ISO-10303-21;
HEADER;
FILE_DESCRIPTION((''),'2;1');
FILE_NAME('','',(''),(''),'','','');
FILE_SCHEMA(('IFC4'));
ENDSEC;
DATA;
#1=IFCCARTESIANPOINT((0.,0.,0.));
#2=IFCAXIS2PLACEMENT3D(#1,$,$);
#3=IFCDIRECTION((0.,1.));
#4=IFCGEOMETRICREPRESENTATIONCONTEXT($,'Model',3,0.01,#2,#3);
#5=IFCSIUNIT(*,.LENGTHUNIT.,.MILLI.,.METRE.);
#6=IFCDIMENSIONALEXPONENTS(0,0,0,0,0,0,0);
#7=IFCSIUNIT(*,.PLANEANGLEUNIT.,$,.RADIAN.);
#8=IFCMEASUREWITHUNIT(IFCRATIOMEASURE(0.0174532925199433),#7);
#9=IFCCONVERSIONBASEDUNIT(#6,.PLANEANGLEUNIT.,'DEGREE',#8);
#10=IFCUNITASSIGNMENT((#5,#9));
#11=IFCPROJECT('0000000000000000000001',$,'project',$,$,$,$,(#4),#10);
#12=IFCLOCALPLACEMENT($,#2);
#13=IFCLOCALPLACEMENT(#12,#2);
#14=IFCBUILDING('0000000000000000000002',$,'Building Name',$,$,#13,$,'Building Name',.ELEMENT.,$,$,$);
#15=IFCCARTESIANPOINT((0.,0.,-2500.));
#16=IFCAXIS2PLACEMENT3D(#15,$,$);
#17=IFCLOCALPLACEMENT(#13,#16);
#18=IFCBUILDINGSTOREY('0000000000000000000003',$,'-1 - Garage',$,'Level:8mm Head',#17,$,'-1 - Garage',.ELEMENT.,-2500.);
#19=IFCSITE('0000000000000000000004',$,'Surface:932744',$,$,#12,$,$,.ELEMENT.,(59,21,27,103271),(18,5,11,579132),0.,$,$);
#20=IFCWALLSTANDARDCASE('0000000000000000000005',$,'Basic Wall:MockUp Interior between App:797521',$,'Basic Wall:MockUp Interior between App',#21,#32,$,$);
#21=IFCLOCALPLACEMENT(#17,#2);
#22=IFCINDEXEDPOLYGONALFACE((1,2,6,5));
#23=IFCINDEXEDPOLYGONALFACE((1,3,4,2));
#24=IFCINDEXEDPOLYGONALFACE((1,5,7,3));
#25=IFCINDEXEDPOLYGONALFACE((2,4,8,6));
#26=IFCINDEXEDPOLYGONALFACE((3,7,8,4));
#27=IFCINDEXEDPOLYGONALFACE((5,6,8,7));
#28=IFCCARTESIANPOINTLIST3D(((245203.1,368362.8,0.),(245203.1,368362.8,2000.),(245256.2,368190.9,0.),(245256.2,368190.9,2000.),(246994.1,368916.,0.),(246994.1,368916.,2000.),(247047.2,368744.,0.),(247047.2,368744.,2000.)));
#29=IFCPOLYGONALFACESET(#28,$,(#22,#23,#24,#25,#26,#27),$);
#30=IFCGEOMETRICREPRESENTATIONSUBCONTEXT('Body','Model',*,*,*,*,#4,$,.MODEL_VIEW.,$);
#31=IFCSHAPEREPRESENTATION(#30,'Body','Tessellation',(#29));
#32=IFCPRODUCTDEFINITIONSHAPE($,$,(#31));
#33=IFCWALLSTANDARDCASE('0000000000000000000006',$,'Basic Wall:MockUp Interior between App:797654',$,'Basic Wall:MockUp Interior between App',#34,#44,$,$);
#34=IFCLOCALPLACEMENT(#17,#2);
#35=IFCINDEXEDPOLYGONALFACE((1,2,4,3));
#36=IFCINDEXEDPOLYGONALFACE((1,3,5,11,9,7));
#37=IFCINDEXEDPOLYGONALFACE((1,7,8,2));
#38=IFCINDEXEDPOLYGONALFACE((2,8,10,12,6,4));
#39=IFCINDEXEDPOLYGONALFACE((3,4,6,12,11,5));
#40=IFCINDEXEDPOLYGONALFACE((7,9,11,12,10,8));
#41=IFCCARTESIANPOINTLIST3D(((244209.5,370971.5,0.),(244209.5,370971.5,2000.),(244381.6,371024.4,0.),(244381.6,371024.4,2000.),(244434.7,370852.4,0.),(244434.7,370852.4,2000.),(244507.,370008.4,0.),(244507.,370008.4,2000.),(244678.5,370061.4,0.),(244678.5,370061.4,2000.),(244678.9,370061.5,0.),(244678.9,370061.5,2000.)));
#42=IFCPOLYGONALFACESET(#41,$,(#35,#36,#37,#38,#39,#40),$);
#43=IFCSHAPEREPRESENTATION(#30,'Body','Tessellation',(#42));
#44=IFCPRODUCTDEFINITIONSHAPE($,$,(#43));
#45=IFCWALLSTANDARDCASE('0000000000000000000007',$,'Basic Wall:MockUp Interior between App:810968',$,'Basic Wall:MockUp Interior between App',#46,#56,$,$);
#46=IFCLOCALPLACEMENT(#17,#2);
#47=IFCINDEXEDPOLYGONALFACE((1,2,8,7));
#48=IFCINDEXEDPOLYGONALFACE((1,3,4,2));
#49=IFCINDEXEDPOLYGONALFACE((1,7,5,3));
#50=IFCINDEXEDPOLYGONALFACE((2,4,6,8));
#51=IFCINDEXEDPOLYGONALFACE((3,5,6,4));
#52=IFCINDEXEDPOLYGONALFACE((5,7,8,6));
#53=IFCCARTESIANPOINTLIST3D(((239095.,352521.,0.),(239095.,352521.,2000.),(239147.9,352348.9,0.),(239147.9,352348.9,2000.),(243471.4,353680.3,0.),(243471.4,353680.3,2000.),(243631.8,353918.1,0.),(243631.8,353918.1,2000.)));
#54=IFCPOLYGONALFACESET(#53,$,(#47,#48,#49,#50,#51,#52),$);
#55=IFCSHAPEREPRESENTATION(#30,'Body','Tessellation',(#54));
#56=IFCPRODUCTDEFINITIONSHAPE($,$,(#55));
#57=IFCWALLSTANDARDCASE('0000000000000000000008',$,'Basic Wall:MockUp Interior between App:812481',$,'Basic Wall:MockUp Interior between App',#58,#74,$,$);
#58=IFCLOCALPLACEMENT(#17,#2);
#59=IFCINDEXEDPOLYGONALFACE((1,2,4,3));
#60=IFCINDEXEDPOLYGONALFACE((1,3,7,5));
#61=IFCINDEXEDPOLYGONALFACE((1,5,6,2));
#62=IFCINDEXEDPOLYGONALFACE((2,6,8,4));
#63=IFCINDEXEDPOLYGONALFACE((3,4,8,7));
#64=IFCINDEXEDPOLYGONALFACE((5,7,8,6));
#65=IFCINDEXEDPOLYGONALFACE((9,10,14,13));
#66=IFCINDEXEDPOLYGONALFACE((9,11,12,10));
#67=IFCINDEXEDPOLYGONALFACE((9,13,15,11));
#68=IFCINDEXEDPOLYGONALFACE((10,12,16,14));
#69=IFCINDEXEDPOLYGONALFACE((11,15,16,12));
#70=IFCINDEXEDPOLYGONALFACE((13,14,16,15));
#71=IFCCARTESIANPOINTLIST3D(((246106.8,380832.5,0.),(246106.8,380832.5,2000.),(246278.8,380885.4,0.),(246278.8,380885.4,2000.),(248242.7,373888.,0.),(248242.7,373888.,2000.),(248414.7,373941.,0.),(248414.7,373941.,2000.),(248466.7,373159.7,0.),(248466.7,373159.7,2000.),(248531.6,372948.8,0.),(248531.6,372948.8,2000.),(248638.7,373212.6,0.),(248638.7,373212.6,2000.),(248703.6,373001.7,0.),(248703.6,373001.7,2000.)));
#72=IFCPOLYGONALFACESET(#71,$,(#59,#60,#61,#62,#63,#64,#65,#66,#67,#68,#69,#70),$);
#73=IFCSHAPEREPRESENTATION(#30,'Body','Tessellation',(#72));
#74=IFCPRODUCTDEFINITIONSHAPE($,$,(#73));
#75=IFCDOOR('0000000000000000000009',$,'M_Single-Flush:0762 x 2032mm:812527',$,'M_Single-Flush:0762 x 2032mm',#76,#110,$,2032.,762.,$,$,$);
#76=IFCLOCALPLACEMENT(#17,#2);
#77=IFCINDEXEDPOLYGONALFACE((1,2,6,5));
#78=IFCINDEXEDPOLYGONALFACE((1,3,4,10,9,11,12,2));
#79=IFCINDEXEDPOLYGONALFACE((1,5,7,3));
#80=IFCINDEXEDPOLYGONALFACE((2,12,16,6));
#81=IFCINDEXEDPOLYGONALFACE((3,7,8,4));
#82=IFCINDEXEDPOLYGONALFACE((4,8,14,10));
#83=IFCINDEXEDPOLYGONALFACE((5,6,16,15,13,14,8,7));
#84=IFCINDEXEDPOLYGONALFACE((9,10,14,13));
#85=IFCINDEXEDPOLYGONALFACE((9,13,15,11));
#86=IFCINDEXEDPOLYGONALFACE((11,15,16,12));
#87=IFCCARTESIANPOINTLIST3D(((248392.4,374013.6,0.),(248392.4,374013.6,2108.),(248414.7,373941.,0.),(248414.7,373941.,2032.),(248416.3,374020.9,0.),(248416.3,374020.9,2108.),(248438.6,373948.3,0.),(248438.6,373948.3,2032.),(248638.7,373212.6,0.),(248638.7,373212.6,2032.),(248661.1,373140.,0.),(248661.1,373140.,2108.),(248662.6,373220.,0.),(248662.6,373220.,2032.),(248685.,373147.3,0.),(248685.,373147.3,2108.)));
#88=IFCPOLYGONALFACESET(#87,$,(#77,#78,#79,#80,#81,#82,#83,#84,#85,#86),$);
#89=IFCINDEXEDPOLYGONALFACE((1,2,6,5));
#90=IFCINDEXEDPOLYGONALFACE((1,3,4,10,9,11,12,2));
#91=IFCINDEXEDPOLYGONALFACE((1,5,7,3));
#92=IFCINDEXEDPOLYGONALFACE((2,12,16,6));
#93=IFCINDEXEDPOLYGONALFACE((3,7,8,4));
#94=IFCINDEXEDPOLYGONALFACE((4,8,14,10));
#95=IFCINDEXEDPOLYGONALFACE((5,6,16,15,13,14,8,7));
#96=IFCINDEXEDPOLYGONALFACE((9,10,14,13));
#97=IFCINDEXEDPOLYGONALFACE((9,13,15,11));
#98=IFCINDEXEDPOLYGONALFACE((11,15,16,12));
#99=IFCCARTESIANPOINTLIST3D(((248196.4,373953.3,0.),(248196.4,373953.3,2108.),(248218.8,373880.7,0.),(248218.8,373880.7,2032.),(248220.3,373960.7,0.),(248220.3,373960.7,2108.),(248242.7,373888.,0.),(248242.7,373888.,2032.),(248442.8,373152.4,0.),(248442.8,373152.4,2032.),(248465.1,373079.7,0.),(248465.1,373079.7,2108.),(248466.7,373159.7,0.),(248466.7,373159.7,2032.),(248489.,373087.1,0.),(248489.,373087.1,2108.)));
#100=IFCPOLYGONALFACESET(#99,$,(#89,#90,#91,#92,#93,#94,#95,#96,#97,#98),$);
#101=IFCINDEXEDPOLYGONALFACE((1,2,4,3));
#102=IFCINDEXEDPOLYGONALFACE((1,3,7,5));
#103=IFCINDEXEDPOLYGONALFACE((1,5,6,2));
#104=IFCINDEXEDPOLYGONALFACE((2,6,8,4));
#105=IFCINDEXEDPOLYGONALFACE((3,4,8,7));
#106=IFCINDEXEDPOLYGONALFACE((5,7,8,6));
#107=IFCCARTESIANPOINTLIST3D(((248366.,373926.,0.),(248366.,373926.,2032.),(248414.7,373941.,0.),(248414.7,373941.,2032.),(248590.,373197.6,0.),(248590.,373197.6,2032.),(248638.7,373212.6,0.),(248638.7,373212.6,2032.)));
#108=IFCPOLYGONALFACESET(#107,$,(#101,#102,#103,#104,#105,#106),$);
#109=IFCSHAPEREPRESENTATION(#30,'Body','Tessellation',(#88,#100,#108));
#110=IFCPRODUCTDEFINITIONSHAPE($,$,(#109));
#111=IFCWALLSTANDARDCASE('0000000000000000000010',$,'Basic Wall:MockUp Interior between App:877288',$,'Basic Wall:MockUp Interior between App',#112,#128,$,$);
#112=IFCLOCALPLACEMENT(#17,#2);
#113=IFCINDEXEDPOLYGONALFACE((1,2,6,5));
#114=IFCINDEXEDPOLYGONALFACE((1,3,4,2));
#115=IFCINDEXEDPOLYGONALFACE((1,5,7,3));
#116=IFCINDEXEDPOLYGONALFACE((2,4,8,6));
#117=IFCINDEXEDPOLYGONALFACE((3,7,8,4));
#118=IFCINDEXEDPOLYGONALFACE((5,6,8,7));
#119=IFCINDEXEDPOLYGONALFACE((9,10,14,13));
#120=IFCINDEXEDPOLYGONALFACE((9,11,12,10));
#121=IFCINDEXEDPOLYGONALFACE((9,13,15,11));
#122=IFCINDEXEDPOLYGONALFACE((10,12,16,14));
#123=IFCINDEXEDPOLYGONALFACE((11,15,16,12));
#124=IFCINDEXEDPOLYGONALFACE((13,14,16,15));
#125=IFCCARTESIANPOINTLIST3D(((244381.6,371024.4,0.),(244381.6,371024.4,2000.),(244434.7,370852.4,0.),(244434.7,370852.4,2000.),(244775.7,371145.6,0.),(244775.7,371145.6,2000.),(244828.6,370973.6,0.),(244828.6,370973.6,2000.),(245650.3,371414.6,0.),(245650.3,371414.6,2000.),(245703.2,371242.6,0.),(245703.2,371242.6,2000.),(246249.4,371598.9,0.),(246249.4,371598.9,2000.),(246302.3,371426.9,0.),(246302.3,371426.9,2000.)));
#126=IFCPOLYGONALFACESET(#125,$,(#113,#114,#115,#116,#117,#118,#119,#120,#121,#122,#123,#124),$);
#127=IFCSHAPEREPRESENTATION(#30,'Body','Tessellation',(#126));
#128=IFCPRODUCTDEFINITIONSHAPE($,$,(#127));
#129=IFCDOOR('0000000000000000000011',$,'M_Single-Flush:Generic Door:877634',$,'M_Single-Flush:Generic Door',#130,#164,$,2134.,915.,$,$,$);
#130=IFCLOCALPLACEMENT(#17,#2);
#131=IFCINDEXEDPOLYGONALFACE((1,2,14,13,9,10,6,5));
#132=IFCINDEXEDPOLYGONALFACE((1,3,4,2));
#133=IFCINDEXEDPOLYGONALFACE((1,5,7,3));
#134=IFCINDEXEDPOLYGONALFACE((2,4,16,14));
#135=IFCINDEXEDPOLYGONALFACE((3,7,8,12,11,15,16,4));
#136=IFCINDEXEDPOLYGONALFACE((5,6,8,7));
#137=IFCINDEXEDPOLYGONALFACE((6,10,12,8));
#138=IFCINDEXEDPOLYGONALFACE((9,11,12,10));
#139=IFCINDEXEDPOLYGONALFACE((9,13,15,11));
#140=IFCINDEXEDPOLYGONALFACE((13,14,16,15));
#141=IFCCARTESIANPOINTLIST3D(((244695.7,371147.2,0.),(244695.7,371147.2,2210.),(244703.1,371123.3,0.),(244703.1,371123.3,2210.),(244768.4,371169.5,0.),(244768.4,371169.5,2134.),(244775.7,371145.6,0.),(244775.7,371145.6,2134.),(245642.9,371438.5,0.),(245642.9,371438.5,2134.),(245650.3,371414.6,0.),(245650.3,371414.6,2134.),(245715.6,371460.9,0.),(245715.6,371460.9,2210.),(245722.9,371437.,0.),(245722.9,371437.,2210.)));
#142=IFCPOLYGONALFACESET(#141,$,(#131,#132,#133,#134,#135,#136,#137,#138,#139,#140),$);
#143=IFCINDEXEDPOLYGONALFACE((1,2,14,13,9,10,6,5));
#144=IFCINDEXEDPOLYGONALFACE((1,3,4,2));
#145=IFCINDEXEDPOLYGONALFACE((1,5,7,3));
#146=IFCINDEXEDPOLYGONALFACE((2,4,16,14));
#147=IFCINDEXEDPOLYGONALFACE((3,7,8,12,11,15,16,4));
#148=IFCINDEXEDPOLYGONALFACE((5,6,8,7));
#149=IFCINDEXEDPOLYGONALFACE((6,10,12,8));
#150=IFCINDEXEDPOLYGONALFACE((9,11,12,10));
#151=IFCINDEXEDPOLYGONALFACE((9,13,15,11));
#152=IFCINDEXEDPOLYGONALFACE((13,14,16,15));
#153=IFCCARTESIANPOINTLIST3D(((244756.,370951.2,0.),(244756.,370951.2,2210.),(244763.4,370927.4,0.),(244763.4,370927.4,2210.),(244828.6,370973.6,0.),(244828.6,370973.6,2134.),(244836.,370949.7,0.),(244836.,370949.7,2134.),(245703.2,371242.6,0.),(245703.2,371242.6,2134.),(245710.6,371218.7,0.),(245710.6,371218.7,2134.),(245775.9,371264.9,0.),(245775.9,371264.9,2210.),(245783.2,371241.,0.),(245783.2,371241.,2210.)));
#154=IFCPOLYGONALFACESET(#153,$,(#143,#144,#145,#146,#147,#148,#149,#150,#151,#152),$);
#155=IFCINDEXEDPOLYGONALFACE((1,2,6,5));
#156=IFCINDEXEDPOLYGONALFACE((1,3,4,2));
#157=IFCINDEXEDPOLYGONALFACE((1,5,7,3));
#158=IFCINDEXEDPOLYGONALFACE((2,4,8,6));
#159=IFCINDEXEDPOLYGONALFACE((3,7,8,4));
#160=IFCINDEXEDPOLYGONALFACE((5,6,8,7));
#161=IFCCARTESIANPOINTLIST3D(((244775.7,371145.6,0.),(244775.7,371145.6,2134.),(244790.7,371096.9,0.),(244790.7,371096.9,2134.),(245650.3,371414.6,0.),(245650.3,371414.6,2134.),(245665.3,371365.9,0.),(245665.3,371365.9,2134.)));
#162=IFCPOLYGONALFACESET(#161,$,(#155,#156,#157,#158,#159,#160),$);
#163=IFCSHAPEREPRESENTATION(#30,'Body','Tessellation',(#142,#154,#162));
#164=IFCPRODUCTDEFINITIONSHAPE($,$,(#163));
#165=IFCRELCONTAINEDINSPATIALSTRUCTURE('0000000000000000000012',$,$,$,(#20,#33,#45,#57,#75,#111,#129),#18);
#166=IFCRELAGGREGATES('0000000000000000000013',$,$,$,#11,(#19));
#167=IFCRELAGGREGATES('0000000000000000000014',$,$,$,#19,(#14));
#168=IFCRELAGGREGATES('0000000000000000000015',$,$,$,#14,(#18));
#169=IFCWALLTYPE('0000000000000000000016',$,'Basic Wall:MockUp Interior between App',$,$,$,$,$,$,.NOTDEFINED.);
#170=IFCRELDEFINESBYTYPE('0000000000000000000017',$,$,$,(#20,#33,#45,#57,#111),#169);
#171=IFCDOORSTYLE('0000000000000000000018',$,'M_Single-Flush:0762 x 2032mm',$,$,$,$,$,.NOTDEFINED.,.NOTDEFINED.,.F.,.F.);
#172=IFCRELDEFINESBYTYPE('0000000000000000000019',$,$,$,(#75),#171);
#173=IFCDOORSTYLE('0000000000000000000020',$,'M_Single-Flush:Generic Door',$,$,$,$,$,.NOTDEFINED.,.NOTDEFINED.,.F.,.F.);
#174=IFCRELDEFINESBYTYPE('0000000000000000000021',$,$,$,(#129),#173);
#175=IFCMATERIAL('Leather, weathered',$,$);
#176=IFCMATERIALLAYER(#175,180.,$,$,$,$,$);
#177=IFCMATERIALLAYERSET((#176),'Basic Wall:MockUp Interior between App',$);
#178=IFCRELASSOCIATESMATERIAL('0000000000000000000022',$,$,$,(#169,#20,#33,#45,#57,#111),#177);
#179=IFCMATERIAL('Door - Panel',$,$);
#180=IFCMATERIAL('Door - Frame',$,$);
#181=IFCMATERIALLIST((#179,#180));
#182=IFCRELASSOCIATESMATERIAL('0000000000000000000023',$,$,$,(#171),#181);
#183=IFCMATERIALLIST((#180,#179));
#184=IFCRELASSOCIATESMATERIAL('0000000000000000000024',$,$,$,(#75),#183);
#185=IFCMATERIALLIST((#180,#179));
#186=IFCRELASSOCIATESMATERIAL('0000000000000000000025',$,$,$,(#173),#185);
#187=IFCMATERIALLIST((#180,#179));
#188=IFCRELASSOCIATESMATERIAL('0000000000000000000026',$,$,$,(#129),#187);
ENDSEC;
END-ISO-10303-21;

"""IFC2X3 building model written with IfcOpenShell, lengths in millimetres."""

from ifc_helpers import new_model, entity, si_unit, converted_unit, direction, frame, frame_2d, origin, place, context, subcontext, project, spatial, polyline, rectangle, outline, extrude, source, transform, mapped, material, material_list, layer, layer_set, layer_usage, type_object, type_shapes, element, fill, save


model = new_model("IFC2X3")

# Units and contexts
model_context = context("Model", 3, precision=0.01, world=origin(), true_north=direction((0.0, 1.0)))
body_context = subcontext(model_context, "Body", "Model", "MODEL_VIEW")
ifc_project = project(units=[si_unit("LENGTHUNIT", "METRE", prefix="MILLI"), converted_unit("PLANEANGLEUNIT", "DEGREE", entity("IfcRatioMeasure", 0.0174532925199433), si_unit("PLANEANGLEUNIT", "RADIAN"), dimensions=[0, 0, 0, 0, 0, 0, 0])], contexts=[model_context])

# Site, building, storey
site_placement = place(None, origin())
site = spatial("IfcSite", under=ifc_project, at=site_placement, Name="Surface:932744", CompositionType="ELEMENT", RefLatitude=(59, 21, 27, 103271), RefLongitude=(18, 5, 11, 579132), RefElevation=0.0)
building_placement = place(site_placement, origin())
building = spatial("IfcBuilding", under=site, at=building_placement, Name="Building Name", LongName="Building Name", CompositionType="ELEMENT")
storey_placement = place(building_placement, frame((0.0, 0.0, -2500.0)))
storey = spatial("IfcBuildingStorey", under=building, at=storey_placement, Name="-1 - Garage", ObjectType="Level:8mm Head", LongName="-1 - Garage", CompositionType="ELEMENT", Elevation=-2500.0)

# Walls
ifc_material_1 = material(Name="Leather, weathered")
ifc_layer_1 = layer(ifc_material_1, 180.0)
ifc_layer_set_1 = layer_set([ifc_layer_1], Name="Basic Wall:MockUp Interior between App")
ifc_layer_usage_1 = layer_usage(ifc_layer_set_1, "AXIS2", "NEGATIVE", 90.0)
wall_type_1 = type_object("IfcWallType", Name="Basic Wall:MockUp Interior between App", PredefinedType="NOTDEFINED", material=ifc_layer_set_1)
wall_1_placement = place(storey_placement, frame((245229.7, 368276.8, 0.0), z_axis=(0.0, 0.0, 1.0), x_axis=(0.955473, 0.29508, 0.0)))
element("IfcWallStandardCase", 1, at=wall_1_placement, inside=storey, type_object=wall_type_1, material=ifc_layer_usage_1, Name="Basic Wall:MockUp Interior between App:797521", ObjectType="Basic Wall:MockUp Interior between App", context=body_context, shape_type="SweptSolid", body=[
    extrude(rectangle(XDim=1874.5, YDim=180.0, at=frame_2d((937.2, 0.0), x_axis=(-1.0, 0.0))), origin(), (0.0, 0.0, 1.0), 2000.0),
])
ifc_layer_usage_2 = layer_usage(ifc_layer_set_1, "AXIS2", "NEGATIVE", 90.0)
wall_2_placement = place(storey_placement, frame((244295.5, 370998.0, 0.0), z_axis=(0.0, 0.0, 1.0), x_axis=(0.29508, -0.955473, 0.0)))
element("IfcWallStandardCase", 2, at=wall_2_placement, inside=storey, type_object=wall_type_1, material=ifc_layer_usage_2, Name="Basic Wall:MockUp Interior between App:797654", ObjectType="Basic Wall:MockUp Interior between App", context=body_context, shape_type="SweptSolid", body=[
    extrude(outline(polyline([(1008.0, -90.0), (1008.0, 89.6), (1008.0, 90.0), (180.2, 90.0), (0.2, 90.0), (0.0, -90.0), (1008.0, -90.0)])), origin(), (0.0, 0.0, 1.0), 2000.0),
])
ifc_layer_usage_3 = layer_usage(ifc_layer_set_1, "AXIS2", "NEGATIVE", 90.0)
wall_3_placement = place(storey_placement, frame((243658.3, 353832.1, 0.0), z_axis=(0.0, 0.0, 1.0), x_axis=(-0.95571, -0.29431, 0.0)))
element("IfcWallStandardCase", 3, at=wall_3_placement, inside=storey, type_object=wall_type_1, material=ifc_layer_usage_3, Name="Basic Wall:MockUp Interior between App:810968", ObjectType="Basic Wall:MockUp Interior between App", context=body_context, shape_type="SweptSolid", body=[
    extrude(outline(polyline([(4747.1, -90.0), (4747.1, 90.0), (223.2, 90.0), (0.0, -90.0), (4747.1, -90.0)])), origin(), (0.0, 0.0, 1.0), 2000.0),
])

# Walls, openings, doors
ifc_layer_usage_4 = layer_usage(ifc_layer_set_1, "AXIS2", "NEGATIVE", 90.0)
wall_4_placement = place(storey_placement, frame((248617.6, 372975.2, 0.0), z_axis=(0.0, 0.0, 1.0), x_axis=(-0.29398, 0.955811, 0.0)))
wall_4 = element("IfcWallStandardCase", 4, at=wall_4_placement, inside=storey, type_object=wall_type_1, material=ifc_layer_usage_4, Name="Basic Wall:MockUp Interior between App:812481", ObjectType="Basic Wall:MockUp Interior between App", context=body_context, shape_type="SweptSolid", body=[
    extrude(rectangle(XDim=8248.2, YDim=180.0, at=frame_2d((4124.1, 0.0), x_axis=(-1.0, 0.0))), origin(), (0.0, 0.0, 1.0), 2000.0),
])
opening_1_placement = place(wall_4_placement, frame((982.7, 90.0, 0.0)))
opening_1 = element("IfcOpeningElement", 5, at=opening_1_placement, cuts=wall_4, ObjectType="Opening", context=body_context, shape_type="SweptSolid", body=[
    extrude(rectangle(XDim=762.0, YDim=2032.0, at=frame_2d((1016.0, 381.0), x_axis=(0.0, 1.0))), frame((0.0, 0.0, 0.0), z_axis=(0.0, -1.0, 0.0), x_axis=(0.0, 0.0, 1.0)), (0.0, 0.0, 1.0), 180.0),
])
ifc_material_2 = material(Name="Door - Frame")
ifc_material_3 = material(Name="Door - Panel")
ifc_material_list_1 = material_list([ifc_material_2, ifc_material_3])
ifc_material_list_2 = material_list([ifc_material_3, ifc_material_2])
door_style_1 = type_object("IfcDoorStyle", Name="M_Single-Flush:0762 x 2032mm", ConstructionType="NOTDEFINED", OperationType="NOTDEFINED", ParameterTakesPrecedence=False, Sizeable=False, material=ifc_material_list_2)
shared_shape_1 = source(origin(), body_context, "Body", "SweptSolid", [
    extrude(outline(polyline([(-457.0, -1073.0), (457.0, -1073.0), (457.0, 1035.0), (381.0, 1035.0), (381.0, -997.0), (-381.0, -997.0), (-381.0, 1035.0), (-457.0, 1035.0), (-457.0, -1073.0)])), frame((381.0, 180.0, 1035.0), z_axis=(0.0, 1.0, 0.0), x_axis=(1.0, 0.0, 0.0)), (0.0, 0.0, 1.0), 25.0),
    extrude(outline(polyline([(-1073.0, -457.0), (1035.0, -457.0), (1035.0, -381.0), (-997.0, -381.0), (-997.0, 381.0), (1035.0, 381.0), (1035.0, 457.0), (-1073.0, 457.0), (-1073.0, -457.0)])), frame((381.0, -25.0, 1035.0), z_axis=(0.0, 1.0, 0.0), x_axis=(0.0, 0.0, -1.0)), (0.0, 0.0, 1.0), 25.0),
    extrude(rectangle(XDim=51.0, YDim=762.0, at=frame_2d((0.0, 0.0), x_axis=(1.0, 0.0))), frame((381.0, 154.5, 0.0), z_axis=(0.0, 0.0, 1.0), x_axis=(0.0, 1.0, 0.0)), (0.0, 0.0, 1.0), 2032.0),
])
type_shapes(door_style_1, [shared_shape_1])
door_1_placement = place(opening_1_placement, frame((0.0, 0.0, 0.0), z_axis=(0.0, 0.0, 1.0), x_axis=(-1.0, 0.0, 0.0)))
door_1 = element("IfcDoor", 6, at=door_1_placement, inside=storey, type_object=door_style_1, material=ifc_material_list_1, Name="M_Single-Flush:0762 x 2032mm:812527", ObjectType="M_Single-Flush:0762 x 2032mm", OverallHeight=2032.0, OverallWidth=762.0, context=body_context, shape_type="MappedRepresentation", body=[
    mapped(shared_shape_1, transform((0.0, 0.0, 0.0), scale=1.0)),
])
fill(opening_1, door_1)
ifc_layer_usage_5 = layer_usage(ifc_layer_set_1, "AXIS2", "NEGATIVE", 90.0)
wall_5_placement = place(storey_placement, frame((246275.9, 371512.9, 0.0), z_axis=(0.0, 0.0, 1.0), x_axis=(-0.955811, -0.29398, 0.0)))
wall_5 = element("IfcWallStandardCase", 7, at=wall_5_placement, inside=storey, type_object=wall_type_1, material=ifc_layer_usage_5, Name="Basic Wall:MockUp Interior between App:877288", ObjectType="Basic Wall:MockUp Interior between App", context=body_context, shape_type="SweptSolid", body=[
    extrude(outline(polyline([(0.0, 90.0), (0.0, -90.0), (1954.2, -90.0), (1954.0, 90.0), (0.0, 90.0)])), origin(), (0.0, 0.0, 1.0), 2000.0),
])
opening_2_placement = place(wall_5_placement, frame((1541.8, 90.0, 0.0)))
opening_2 = element("IfcOpeningElement", 8, at=opening_2_placement, cuts=wall_5, ObjectType="Opening", context=body_context, shape_type="SweptSolid", body=[
    extrude(rectangle(XDim=915.0, YDim=2134.0, at=frame_2d((1067.0, 457.5), x_axis=(0.0, 1.0))), frame((0.0, 0.0, 0.0), z_axis=(0.0, -1.0, 0.0), x_axis=(0.0, 0.0, 1.0)), (0.0, 0.0, 1.0), 180.0),
])
ifc_material_list_3 = material_list([ifc_material_2, ifc_material_3])
ifc_material_list_4 = material_list([ifc_material_2, ifc_material_3])
door_style_2 = type_object("IfcDoorStyle", Name="M_Single-Flush:Generic Door", ConstructionType="NOTDEFINED", OperationType="NOTDEFINED", ParameterTakesPrecedence=False, Sizeable=False, material=ifc_material_list_4)
shared_shape_2 = source(origin(), body_context, "Body", "SweptSolid", [
    extrude(outline(polyline([(-533.5, -1124.0), (533.5, -1124.0), (533.5, 1086.0), (457.5, 1086.0), (457.5, -1048.0), (-457.5, -1048.0), (-457.5, 1086.0), (-533.5, 1086.0), (-533.5, -1124.0)])), frame((457.5, 180.0, 1086.0), z_axis=(0.0, 1.0, 0.0), x_axis=(1.0, 0.0, 0.0)), (0.0, 0.0, 1.0), 25.0),
    extrude(outline(polyline([(-1124.0, -533.5), (1086.0, -533.5), (1086.0, -457.5), (-1048.0, -457.5), (-1048.0, 457.5), (1086.0, 457.5), (1086.0, 533.5), (-1124.0, 533.5), (-1124.0, -533.5)])), frame((457.5, -25.0, 1086.0), z_axis=(0.0, 1.0, 0.0), x_axis=(0.0, 0.0, -1.0)), (0.0, 0.0, 1.0), 25.0),
    extrude(rectangle(XDim=51.0, YDim=915.0, at=frame_2d((0.0, 0.0), x_axis=(1.0, 0.0))), frame((457.5, 154.5, 0.0), z_axis=(0.0, 0.0, 1.0), x_axis=(0.0, 1.0, 0.0)), (0.0, 0.0, 1.0), 2134.0),
])
type_shapes(door_style_2, [shared_shape_2])
door_2_placement = place(opening_2_placement, frame((0.0, 0.0, 0.0), z_axis=(0.0, 0.0, 1.0), x_axis=(-1.0, 0.0, 0.0)))
door_2 = element("IfcDoor", 9, at=door_2_placement, inside=storey, type_object=door_style_2, material=ifc_material_list_3, Name="M_Single-Flush:Generic Door:877634", ObjectType="M_Single-Flush:Generic Door", OverallHeight=2134.0, OverallWidth=915.0, context=body_context, shape_type="MappedRepresentation", body=[
    mapped(shared_shape_2, transform((0.0, 0.0, 0.0), scale=1.0)),
])
fill(opening_2, door_2)

save(model, "model.ifc")
